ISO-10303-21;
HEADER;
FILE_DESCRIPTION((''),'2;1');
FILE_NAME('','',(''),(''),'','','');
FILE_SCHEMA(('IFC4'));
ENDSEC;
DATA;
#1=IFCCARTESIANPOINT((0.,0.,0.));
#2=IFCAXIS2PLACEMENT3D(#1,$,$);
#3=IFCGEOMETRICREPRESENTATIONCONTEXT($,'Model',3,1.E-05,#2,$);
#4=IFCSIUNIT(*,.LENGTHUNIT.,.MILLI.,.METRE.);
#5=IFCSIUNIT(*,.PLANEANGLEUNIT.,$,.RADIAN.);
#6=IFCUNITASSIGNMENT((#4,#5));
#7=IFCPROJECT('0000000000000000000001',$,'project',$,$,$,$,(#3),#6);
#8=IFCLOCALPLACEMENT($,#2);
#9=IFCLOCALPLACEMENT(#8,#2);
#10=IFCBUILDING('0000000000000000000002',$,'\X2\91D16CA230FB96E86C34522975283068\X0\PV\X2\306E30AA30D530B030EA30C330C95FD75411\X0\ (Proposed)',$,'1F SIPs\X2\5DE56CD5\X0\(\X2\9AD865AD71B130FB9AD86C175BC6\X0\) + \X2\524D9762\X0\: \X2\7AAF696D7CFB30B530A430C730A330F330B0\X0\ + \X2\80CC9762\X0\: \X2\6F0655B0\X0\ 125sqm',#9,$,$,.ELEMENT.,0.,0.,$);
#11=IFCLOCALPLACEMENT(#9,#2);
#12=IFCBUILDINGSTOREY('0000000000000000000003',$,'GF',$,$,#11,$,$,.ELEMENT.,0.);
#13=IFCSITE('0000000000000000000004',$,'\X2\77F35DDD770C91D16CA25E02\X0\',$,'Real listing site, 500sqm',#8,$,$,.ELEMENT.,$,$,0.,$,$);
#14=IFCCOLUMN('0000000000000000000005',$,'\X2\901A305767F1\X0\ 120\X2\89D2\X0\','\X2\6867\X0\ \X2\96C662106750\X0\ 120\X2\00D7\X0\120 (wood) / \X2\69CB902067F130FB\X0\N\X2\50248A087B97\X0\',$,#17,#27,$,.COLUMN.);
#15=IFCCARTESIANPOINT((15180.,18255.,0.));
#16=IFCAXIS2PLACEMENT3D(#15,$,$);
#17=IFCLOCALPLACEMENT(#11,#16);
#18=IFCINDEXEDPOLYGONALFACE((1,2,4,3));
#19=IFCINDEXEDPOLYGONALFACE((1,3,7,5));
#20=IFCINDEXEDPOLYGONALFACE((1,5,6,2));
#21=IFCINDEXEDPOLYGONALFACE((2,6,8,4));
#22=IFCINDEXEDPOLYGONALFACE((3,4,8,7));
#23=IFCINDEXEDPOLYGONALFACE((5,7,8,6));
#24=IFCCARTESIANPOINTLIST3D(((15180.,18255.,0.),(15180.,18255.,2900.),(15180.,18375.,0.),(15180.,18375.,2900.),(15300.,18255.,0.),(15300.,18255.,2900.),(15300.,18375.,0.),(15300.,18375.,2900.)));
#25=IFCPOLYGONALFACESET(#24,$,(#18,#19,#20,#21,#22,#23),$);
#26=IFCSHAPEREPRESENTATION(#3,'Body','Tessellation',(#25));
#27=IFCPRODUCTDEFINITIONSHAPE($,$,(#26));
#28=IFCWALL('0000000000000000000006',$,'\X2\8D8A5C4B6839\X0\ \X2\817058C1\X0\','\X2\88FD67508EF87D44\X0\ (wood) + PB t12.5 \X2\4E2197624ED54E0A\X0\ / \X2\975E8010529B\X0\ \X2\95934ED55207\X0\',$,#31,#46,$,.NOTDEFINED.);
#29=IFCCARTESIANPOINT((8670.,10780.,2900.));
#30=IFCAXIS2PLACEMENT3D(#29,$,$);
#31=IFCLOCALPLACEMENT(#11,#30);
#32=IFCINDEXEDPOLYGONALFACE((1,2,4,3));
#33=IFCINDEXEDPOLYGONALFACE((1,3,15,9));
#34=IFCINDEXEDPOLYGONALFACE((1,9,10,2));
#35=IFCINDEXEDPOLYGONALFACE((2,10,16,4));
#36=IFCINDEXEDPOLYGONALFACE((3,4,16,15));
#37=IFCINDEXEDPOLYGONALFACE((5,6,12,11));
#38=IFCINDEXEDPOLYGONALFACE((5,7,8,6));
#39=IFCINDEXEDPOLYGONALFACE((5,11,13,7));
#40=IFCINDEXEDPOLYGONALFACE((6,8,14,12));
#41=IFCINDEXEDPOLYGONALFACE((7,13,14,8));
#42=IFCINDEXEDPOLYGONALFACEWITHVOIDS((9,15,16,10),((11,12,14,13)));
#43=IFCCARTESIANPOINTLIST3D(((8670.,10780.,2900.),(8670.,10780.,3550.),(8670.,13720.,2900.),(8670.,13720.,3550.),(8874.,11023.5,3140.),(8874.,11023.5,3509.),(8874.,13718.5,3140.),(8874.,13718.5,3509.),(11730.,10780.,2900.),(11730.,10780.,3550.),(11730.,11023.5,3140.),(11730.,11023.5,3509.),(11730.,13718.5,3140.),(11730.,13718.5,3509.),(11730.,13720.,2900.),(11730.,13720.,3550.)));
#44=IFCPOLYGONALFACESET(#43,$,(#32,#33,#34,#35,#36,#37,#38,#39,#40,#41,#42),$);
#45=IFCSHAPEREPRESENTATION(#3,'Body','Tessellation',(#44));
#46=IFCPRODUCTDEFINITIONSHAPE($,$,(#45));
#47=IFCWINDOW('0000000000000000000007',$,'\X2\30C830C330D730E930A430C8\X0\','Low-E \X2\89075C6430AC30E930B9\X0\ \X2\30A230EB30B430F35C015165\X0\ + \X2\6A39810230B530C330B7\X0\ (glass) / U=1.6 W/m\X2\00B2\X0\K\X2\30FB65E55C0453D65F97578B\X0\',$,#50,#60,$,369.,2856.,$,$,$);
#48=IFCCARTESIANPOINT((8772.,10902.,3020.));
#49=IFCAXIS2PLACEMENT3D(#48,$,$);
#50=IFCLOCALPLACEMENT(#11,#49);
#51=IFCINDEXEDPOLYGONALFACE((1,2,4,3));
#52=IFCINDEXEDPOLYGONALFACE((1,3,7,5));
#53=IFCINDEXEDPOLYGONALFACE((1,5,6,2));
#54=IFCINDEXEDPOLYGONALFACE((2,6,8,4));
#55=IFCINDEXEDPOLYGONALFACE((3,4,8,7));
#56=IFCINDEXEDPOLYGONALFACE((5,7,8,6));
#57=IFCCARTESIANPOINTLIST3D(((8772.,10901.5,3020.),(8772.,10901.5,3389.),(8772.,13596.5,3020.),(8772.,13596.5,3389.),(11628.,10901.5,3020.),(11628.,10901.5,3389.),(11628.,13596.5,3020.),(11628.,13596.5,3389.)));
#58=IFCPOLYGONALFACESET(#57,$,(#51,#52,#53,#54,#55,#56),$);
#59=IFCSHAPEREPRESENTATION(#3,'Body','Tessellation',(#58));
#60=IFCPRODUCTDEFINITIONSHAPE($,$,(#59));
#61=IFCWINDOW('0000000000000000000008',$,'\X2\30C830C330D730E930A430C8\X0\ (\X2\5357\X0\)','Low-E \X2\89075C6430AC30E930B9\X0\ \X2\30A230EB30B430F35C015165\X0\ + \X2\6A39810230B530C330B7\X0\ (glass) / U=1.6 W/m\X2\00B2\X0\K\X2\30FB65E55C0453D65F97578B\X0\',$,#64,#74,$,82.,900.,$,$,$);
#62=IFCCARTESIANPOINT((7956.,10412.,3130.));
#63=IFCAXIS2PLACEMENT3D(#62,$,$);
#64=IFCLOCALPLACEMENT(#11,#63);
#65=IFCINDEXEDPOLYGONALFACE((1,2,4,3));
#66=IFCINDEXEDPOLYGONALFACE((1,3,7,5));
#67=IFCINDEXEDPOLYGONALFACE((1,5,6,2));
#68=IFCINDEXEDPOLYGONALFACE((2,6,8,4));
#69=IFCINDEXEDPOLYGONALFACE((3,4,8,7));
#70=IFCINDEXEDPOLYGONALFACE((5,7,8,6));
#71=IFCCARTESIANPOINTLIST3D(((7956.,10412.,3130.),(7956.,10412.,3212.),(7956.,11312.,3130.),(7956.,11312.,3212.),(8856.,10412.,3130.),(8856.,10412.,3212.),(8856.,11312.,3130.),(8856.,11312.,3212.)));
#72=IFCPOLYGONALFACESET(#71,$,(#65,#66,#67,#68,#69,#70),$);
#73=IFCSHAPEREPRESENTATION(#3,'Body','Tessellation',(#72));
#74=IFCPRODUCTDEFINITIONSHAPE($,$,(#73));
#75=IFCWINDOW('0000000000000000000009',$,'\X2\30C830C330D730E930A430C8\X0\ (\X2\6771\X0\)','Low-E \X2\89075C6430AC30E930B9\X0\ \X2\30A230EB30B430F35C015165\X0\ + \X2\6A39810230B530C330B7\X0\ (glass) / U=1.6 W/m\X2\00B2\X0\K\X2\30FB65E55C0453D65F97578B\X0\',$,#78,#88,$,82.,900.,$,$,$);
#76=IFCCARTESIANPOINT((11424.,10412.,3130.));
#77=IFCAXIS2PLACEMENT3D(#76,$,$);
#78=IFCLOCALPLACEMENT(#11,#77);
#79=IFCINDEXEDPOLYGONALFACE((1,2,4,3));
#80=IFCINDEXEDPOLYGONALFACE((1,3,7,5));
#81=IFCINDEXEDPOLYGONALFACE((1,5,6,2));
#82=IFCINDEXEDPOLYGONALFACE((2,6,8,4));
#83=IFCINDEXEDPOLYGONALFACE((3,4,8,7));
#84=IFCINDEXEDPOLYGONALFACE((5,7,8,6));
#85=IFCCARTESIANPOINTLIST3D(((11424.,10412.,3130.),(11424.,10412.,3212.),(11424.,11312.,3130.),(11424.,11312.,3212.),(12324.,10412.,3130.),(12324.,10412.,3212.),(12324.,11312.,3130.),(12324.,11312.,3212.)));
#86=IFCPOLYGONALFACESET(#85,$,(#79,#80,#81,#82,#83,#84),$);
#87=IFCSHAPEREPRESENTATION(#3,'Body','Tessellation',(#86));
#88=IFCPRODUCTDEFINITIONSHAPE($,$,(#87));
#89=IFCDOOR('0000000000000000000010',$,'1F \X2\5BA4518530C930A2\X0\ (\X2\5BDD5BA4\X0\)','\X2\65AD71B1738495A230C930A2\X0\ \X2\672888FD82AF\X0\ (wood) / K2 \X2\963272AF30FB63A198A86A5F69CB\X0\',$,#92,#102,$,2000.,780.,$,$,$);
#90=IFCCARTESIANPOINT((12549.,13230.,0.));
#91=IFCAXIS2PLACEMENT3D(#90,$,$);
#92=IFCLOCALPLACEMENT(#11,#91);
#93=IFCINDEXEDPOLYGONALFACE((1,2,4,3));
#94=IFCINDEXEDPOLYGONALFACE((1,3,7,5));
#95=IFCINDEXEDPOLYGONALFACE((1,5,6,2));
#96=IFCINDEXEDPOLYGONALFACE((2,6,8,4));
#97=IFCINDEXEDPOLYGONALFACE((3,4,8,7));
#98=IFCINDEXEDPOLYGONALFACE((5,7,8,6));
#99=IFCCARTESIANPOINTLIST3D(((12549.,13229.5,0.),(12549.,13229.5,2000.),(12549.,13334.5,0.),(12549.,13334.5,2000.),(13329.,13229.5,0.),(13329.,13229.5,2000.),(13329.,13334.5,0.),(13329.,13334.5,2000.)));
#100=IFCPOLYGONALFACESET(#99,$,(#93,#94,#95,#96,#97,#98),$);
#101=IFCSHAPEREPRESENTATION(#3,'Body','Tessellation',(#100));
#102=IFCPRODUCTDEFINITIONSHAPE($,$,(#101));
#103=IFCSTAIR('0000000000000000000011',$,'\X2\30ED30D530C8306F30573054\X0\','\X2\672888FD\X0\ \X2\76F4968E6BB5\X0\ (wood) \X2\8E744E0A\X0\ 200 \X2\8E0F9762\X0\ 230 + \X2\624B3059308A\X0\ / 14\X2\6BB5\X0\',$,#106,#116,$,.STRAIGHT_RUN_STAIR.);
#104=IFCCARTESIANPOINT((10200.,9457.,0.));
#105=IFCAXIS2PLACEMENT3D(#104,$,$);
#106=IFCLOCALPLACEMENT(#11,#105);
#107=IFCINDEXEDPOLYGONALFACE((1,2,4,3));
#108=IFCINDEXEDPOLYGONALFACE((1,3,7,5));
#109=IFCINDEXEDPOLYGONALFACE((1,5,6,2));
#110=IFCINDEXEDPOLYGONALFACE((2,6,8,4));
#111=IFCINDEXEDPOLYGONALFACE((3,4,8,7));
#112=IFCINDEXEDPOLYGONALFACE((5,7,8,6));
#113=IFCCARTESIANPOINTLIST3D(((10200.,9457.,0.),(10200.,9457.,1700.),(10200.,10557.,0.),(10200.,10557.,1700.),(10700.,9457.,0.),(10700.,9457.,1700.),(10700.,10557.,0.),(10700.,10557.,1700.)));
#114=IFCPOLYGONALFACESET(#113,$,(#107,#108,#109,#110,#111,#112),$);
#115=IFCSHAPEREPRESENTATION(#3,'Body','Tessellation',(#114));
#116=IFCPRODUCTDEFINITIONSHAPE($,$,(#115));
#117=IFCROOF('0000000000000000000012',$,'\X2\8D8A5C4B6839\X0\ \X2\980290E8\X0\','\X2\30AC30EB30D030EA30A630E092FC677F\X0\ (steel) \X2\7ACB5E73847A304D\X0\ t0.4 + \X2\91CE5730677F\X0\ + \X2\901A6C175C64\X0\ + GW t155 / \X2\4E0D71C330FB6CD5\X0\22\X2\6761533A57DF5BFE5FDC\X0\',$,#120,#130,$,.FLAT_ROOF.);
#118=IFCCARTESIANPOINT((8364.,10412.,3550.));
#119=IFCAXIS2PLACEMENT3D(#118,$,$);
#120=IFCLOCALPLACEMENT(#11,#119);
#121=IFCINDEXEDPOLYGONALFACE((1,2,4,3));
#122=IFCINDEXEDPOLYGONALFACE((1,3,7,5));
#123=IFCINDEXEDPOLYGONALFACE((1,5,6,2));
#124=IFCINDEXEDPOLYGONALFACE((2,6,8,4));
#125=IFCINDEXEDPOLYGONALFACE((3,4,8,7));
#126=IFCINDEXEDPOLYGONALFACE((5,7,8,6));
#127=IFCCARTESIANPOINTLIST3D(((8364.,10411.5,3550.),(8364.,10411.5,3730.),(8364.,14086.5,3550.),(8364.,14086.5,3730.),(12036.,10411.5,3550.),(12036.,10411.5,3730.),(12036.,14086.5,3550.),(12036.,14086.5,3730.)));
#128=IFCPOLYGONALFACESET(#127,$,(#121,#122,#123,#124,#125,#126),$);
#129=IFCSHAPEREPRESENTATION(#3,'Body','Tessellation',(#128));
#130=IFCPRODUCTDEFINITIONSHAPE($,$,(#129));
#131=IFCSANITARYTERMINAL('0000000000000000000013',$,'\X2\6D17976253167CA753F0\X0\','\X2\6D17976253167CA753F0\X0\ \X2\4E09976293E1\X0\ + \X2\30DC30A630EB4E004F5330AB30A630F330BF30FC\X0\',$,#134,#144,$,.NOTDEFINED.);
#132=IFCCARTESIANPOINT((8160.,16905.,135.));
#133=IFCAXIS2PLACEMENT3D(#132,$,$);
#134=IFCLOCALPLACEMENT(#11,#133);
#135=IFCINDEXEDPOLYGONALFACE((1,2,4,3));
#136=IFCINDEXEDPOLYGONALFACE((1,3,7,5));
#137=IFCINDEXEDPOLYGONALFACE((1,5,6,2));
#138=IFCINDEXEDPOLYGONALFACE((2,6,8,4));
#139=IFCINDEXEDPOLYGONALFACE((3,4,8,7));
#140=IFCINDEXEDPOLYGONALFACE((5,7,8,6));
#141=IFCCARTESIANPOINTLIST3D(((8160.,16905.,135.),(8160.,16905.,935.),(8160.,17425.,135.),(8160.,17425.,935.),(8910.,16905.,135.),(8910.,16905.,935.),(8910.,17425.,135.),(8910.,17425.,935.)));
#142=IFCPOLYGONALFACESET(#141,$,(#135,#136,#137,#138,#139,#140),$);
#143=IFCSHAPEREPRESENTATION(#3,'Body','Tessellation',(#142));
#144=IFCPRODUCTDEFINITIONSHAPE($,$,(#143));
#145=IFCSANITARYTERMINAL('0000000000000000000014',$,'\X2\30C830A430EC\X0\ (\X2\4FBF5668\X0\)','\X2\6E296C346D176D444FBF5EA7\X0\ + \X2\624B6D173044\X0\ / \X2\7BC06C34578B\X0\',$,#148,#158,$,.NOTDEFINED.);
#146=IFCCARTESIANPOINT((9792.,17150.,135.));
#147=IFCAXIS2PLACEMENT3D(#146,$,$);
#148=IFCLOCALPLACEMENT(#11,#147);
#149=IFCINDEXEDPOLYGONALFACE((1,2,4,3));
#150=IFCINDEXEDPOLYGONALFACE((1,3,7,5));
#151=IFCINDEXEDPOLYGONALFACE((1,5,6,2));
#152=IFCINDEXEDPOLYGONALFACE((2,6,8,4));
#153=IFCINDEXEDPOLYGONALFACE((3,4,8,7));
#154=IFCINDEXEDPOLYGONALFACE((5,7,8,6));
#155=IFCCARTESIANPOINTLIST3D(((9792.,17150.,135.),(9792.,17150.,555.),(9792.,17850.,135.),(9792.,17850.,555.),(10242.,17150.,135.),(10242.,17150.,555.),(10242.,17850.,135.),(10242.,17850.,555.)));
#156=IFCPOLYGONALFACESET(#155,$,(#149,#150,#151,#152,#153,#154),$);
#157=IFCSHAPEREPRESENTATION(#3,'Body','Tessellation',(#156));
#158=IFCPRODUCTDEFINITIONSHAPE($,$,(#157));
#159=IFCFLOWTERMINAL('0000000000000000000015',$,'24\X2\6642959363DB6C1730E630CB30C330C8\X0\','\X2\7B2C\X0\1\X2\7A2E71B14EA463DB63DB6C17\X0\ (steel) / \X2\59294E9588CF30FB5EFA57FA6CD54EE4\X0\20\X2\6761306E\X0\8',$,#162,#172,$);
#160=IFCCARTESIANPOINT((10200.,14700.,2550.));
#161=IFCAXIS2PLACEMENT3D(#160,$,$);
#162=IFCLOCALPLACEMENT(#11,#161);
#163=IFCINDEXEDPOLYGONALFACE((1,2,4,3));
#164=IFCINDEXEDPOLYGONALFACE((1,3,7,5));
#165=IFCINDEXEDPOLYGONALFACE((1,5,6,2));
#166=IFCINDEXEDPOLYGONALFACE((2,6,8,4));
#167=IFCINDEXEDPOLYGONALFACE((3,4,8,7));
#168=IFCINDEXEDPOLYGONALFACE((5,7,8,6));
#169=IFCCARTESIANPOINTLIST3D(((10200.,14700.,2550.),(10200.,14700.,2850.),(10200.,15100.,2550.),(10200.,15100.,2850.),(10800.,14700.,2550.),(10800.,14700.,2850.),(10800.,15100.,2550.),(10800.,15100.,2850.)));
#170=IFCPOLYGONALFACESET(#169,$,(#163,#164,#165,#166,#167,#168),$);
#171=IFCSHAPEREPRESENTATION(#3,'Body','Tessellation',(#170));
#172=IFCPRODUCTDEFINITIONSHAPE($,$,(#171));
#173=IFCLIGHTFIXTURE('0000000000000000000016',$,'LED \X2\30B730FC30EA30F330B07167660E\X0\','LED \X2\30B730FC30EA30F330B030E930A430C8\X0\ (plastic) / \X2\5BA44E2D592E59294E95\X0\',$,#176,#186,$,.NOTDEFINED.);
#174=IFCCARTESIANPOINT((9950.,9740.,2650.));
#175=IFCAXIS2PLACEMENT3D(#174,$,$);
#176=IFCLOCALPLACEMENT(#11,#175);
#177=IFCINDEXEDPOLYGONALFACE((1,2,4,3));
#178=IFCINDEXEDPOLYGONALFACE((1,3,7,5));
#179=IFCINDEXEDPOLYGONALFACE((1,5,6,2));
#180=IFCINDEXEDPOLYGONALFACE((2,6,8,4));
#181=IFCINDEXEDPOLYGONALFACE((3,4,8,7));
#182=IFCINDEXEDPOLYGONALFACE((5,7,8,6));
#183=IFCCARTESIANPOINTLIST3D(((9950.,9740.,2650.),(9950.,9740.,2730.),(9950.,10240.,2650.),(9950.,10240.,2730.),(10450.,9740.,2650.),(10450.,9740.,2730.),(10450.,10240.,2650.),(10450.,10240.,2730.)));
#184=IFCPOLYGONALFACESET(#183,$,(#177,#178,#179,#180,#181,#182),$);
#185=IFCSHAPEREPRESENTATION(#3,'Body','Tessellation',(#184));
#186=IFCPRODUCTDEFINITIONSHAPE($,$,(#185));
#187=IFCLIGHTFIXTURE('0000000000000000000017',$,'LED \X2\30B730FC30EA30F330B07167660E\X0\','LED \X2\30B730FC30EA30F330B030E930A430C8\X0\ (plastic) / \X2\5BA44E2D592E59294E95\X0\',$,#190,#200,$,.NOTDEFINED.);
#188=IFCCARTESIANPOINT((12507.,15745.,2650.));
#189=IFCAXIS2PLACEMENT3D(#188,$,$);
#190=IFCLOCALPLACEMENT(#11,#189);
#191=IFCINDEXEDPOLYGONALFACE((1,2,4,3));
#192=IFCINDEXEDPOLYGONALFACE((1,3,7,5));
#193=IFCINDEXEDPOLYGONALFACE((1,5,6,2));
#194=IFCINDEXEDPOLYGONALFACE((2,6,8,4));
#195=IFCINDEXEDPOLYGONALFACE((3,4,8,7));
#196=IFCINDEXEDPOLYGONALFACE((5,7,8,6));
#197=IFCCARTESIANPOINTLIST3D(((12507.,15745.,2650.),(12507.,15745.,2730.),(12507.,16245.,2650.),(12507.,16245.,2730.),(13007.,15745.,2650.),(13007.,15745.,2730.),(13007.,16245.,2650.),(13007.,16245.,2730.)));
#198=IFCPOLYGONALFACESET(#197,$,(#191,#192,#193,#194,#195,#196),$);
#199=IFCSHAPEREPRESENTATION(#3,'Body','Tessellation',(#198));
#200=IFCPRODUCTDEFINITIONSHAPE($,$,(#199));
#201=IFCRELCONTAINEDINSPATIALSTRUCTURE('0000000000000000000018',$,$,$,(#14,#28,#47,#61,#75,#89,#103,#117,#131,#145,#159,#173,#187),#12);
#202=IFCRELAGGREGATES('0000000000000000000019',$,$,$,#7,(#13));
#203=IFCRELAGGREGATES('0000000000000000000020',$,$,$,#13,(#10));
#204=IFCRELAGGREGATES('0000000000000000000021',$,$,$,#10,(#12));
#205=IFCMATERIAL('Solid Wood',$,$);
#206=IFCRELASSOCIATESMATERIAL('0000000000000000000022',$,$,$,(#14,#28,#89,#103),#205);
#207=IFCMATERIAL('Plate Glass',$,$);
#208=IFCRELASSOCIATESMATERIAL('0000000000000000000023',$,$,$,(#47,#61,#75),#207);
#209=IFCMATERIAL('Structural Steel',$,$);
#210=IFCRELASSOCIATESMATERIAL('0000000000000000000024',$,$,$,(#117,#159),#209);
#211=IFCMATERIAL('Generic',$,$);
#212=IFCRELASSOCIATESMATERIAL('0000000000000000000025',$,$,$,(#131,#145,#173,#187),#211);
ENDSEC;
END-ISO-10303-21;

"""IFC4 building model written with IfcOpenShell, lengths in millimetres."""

from ifc_helpers import new_model, si_unit, frame, frame_2d, origin, place, context, project, spatial, rectangle, extrude, material, element, fill, save


model = new_model("IFC4")

# Units and contexts
model_context = context("Model", 3, precision=1e-05, world=origin())
ifc_project = project(units=[si_unit("LENGTHUNIT", "METRE", prefix="MILLI"), si_unit("PLANEANGLEUNIT", "RADIAN")], contexts=[model_context])

# Site, building, storey
site_placement = place(None, origin())
site = spatial("IfcSite", under=ifc_project, at=site_placement, Name="石川県金沢市", ObjectType="Real listing site, 500sqm", CompositionType="ELEMENT", RefElevation=0.0)
building_placement = place(site_placement, origin())
building = spatial("IfcBuilding", under=site, at=building_placement, Name="金沢・雨水利用とPVのオフグリッド志向 (Proposed)", ObjectType="1F SIPs工法(高断熱・高気密) + 前面: 窯業系サイディング + 背面: 漆喰 125sqm", CompositionType="ELEMENT", ElevationOfRefHeight=0.0, ElevationOfTerrain=0.0)
storey_placement = place(building_placement, origin())
storey = spatial("IfcBuildingStorey", under=building, at=storey_placement, Name="GF", CompositionType="ELEMENT", Elevation=0.0)

# Column
ifc_material_1 = material(Name="Solid Wood")
column_1_placement = place(storey_placement, frame((15180.0, 18255.0, 0.0)))
element("IfcColumn", 1, at=column_1_placement, inside=storey, material=ifc_material_1, Name="通し柱 120角", Description="桧 集成材 120×120 (wood) / 構造柱・N値計算", PredefinedType="COLUMN", context=model_context, shape_type="SweptSolid", body=[
    extrude(rectangle(XDim=120.0, YDim=120.0, at=frame_2d((60.0, 60.0))), frame((15180.0, 18255.0, 0.0)), (0.0, 0.0, 1.0), 2900.0),
])

# Wall, openings, windows
wall_1_placement = place(storey_placement, frame((8670.0, 10780.0, 2900.0)))
wall_1 = element("IfcWall", 2, at=wall_1_placement, inside=storey, material=ifc_material_1, Name="越屋根 腰壁", Description="製材軸組 (wood) + PB t12.5 両面仕上 / 非耐力 間仕切", PredefinedType="NOTDEFINED", context=model_context, shape_type="SweptSolid", body=[
    extrude(rectangle(XDim=3060.0, YDim=2940.0, at=frame_2d((1530.0, 1470.0))), frame((8670.0, 10780.0, 2900.0)), (0.0, 0.0, 1.0), 650.0),
])
opening_1_placement = place(storey_placement, frame((8772.0, 10902.0, 3020.0)))
opening_1 = element("IfcOpeningElement", 3, at=opening_1_placement, cuts=wall_1, PredefinedType="NOTDEFINED", context=model_context, shape_type="SweptSolid", body=[
    extrude(rectangle(XDim=2856.0, YDim=2695.0, at=frame_2d((1428.0, 1347.0))), frame((8772.0, 10902.0, 3020.0)), (0.0, 0.0, 1.0), 369.0),
])
opening_2_placement = place(storey_placement, frame((7956.0, 10412.0, 3130.0)))
opening_2 = element("IfcOpeningElement", 4, at=opening_2_placement, cuts=wall_1, PredefinedType="NOTDEFINED", context=model_context, shape_type="SweptSolid", body=[
    extrude(rectangle(XDim=900.0, YDim=900.0, at=frame_2d((450.0, 450.0))), frame((7956.0, 10412.0, 3130.0)), (0.0, 0.0, 1.0), 82.0),
])
opening_3_placement = place(storey_placement, frame((11424.0, 10412.0, 3130.0)))
opening_3 = element("IfcOpeningElement", 5, at=opening_3_placement, cuts=wall_1, PredefinedType="NOTDEFINED", context=model_context, shape_type="SweptSolid", body=[
    extrude(rectangle(XDim=900.0, YDim=900.0, at=frame_2d((450.0, 450.0))), frame((11424.0, 10412.0, 3130.0)), (0.0, 0.0, 1.0), 82.0),
])
ifc_material_2 = material(Name="Plate Glass")
window_1_placement = place(storey_placement, frame((8772.0, 10902.0, 3020.0)))
window_1 = element("IfcWindow", 6, at=window_1_placement, inside=storey, material=ifc_material_2, Name="トップライト", Description="Low-E 複層ガラス アルゴン封入 + 樹脂サッシ (glass) / U=1.6 W/m²K・日射取得型", OverallHeight=369.0, OverallWidth=2856.0, context=model_context, shape_type="SweptSolid", body=[
    extrude(rectangle(XDim=2856.0, YDim=2695.0, at=frame_2d((1428.0, 1347.0))), frame((8772.0, 10902.0, 3020.0)), (0.0, 0.0, 1.0), 369.0),
])
fill(opening_1, window_1)
window_2_placement = place(storey_placement, frame((7956.0, 10412.0, 3130.0)))
window_2 = element("IfcWindow", 7, at=window_2_placement, inside=storey, material=ifc_material_2, Name="トップライト (南)", Description="Low-E 複層ガラス アルゴン封入 + 樹脂サッシ (glass) / U=1.6 W/m²K・日射取得型", OverallHeight=82.0, OverallWidth=900.0, context=model_context, shape_type="SweptSolid", body=[
    extrude(rectangle(XDim=900.0, YDim=900.0, at=frame_2d((450.0, 450.0))), frame((7956.0, 10412.0, 3130.0)), (0.0, 0.0, 1.0), 82.0),
])
fill(opening_2, window_2)
window_3_placement = place(storey_placement, frame((11424.0, 10412.0, 3130.0)))
window_3 = element("IfcWindow", 8, at=window_3_placement, inside=storey, material=ifc_material_2, Name="トップライト (東)", Description="Low-E 複層ガラス アルゴン封入 + 樹脂サッシ (glass) / U=1.6 W/m²K・日射取得型", OverallHeight=82.0, OverallWidth=900.0, context=model_context, shape_type="SweptSolid", body=[
    extrude(rectangle(XDim=900.0, YDim=900.0, at=frame_2d((450.0, 450.0))), frame((11424.0, 10412.0, 3130.0)), (0.0, 0.0, 1.0), 82.0),
])
fill(opening_3, window_3)

# Door
door_placement = place(storey_placement, frame((12549.0, 13230.0, 0.0)))
element("IfcDoor", 9, at=door_placement, inside=storey, material=ifc_material_1, Name="1F 室内ドア (寝室)", Description="断熱玄関ドア 木製芯 (wood) / K2 防犯・採風機構", OverallHeight=2000.0, OverallWidth=780.0, context=model_context, shape_type="SweptSolid", body=[
    extrude(rectangle(XDim=780.0, YDim=105.0, at=frame_2d((390.0, 52.0))), frame((12549.0, 13230.0, 0.0)), (0.0, 0.0, 1.0), 2000.0),
])

# Stair
stair_placement = place(storey_placement, frame((10200.0, 9457.0, 0.0)))
element("IfcStair", 10, at=stair_placement, inside=storey, material=ifc_material_1, Name="ロフトはしご", Description="木製 直階段 (wood) 蹴上 200 踏面 230 + 手すり / 14段", PredefinedType="STRAIGHT_RUN_STAIR", context=model_context, shape_type="SweptSolid", body=[
    extrude(rectangle(XDim=500.0, YDim=1100.0, at=frame_2d((250.0, 550.0))), frame((10200.0, 9457.0, 0.0)), (0.0, 0.0, 1.0), 1700.0),
])

# Roof
ifc_material_3 = material(Name="Structural Steel")
roof_placement = place(storey_placement, frame((8364.0, 10412.0, 3550.0)))
element("IfcRoof", 11, at=roof_placement, inside=storey, material=ifc_material_3, Name="越屋根 頂部", Description="ガルバリウム鋼板 (steel) 立平葺き t0.4 + 野地板 + 通気層 + GW t155 / 不燃・法22条区域対応", PredefinedType="FLAT_ROOF", context=model_context, shape_type="SweptSolid", body=[
    extrude(rectangle(XDim=3672.0, YDim=3675.0, at=frame_2d((1836.0, 1837.0))), frame((8364.0, 10412.0, 3550.0)), (0.0, 0.0, 1.0), 180.0),
])

# Sanitary terminals
ifc_material_4 = material(Name="Generic")
sanitary_terminal_1_placement = place(storey_placement, frame((8160.0, 16905.0, 135.0)))
element("IfcSanitaryTerminal", 12, at=sanitary_terminal_1_placement, inside=storey, material=ifc_material_4, Name="洗面化粧台", Description="洗面化粧台 三面鏡 + ボウル一体カウンター", PredefinedType="NOTDEFINED", context=model_context, shape_type="SweptSolid", body=[
    extrude(rectangle(XDim=750.0, YDim=520.0, at=frame_2d((375.0, 260.0))), frame((8160.0, 16905.0, 135.0)), (0.0, 0.0, 1.0), 800.0),
])
sanitary_terminal_2_placement = place(storey_placement, frame((9792.0, 17150.0, 135.0)))
element("IfcSanitaryTerminal", 13, at=sanitary_terminal_2_placement, inside=storey, material=ifc_material_4, Name="トイレ (便器)", Description="温水洗浄便座 + 手洗い / 節水型", PredefinedType="NOTDEFINED", context=model_context, shape_type="SweptSolid", body=[
    extrude(rectangle(XDim=450.0, YDim=700.0, at=frame_2d((225.0, 350.0))), frame((9792.0, 17150.0, 135.0)), (0.0, 0.0, 1.0), 420.0),
])

# Flow terminal
flow_terminal_placement = place(storey_placement, frame((10200.0, 14700.0, 2550.0)))
element("IfcFlowTerminal", 14, at=flow_terminal_placement, inside=storey, material=ifc_material_3, Name="24時間換気ユニット", Description="第1種熱交換換気 (steel) / 天井裏・建基法令20条の8", context=model_context, shape_type="SweptSolid", body=[
    extrude(rectangle(XDim=600.0, YDim=400.0, at=frame_2d((300.0, 200.0))), frame((10200.0, 14700.0, 2550.0)), (0.0, 0.0, 1.0), 300.0),
])

# Light fixtures
light_fixture_1_placement = place(storey_placement, frame((9950.0, 9740.0, 2650.0)))
element("IfcLightFixture", 15, at=light_fixture_1_placement, inside=storey, material=ifc_material_4, Name="LED シーリング照明", Description="LED シーリングライト (plastic) / 室中央天井", PredefinedType="NOTDEFINED", context=model_context, shape_type="SweptSolid", body=[
    extrude(rectangle(XDim=500.0, YDim=500.0, at=frame_2d((250.0, 250.0))), frame((9950.0, 9740.0, 2650.0)), (0.0, 0.0, 1.0), 80.0),
])
light_fixture_2_placement = place(storey_placement, frame((12507.0, 15745.0, 2650.0)))
element("IfcLightFixture", 16, at=light_fixture_2_placement, inside=storey, material=ifc_material_4, Name="LED シーリング照明", Description="LED シーリングライト (plastic) / 室中央天井", PredefinedType="NOTDEFINED", context=model_context, shape_type="SweptSolid", body=[
    extrude(rectangle(XDim=500.0, YDim=500.0, at=frame_2d((250.0, 250.0))), frame((12507.0, 15745.0, 2650.0)), (0.0, 0.0, 1.0), 80.0),
])

save(model, "model.ifc")
